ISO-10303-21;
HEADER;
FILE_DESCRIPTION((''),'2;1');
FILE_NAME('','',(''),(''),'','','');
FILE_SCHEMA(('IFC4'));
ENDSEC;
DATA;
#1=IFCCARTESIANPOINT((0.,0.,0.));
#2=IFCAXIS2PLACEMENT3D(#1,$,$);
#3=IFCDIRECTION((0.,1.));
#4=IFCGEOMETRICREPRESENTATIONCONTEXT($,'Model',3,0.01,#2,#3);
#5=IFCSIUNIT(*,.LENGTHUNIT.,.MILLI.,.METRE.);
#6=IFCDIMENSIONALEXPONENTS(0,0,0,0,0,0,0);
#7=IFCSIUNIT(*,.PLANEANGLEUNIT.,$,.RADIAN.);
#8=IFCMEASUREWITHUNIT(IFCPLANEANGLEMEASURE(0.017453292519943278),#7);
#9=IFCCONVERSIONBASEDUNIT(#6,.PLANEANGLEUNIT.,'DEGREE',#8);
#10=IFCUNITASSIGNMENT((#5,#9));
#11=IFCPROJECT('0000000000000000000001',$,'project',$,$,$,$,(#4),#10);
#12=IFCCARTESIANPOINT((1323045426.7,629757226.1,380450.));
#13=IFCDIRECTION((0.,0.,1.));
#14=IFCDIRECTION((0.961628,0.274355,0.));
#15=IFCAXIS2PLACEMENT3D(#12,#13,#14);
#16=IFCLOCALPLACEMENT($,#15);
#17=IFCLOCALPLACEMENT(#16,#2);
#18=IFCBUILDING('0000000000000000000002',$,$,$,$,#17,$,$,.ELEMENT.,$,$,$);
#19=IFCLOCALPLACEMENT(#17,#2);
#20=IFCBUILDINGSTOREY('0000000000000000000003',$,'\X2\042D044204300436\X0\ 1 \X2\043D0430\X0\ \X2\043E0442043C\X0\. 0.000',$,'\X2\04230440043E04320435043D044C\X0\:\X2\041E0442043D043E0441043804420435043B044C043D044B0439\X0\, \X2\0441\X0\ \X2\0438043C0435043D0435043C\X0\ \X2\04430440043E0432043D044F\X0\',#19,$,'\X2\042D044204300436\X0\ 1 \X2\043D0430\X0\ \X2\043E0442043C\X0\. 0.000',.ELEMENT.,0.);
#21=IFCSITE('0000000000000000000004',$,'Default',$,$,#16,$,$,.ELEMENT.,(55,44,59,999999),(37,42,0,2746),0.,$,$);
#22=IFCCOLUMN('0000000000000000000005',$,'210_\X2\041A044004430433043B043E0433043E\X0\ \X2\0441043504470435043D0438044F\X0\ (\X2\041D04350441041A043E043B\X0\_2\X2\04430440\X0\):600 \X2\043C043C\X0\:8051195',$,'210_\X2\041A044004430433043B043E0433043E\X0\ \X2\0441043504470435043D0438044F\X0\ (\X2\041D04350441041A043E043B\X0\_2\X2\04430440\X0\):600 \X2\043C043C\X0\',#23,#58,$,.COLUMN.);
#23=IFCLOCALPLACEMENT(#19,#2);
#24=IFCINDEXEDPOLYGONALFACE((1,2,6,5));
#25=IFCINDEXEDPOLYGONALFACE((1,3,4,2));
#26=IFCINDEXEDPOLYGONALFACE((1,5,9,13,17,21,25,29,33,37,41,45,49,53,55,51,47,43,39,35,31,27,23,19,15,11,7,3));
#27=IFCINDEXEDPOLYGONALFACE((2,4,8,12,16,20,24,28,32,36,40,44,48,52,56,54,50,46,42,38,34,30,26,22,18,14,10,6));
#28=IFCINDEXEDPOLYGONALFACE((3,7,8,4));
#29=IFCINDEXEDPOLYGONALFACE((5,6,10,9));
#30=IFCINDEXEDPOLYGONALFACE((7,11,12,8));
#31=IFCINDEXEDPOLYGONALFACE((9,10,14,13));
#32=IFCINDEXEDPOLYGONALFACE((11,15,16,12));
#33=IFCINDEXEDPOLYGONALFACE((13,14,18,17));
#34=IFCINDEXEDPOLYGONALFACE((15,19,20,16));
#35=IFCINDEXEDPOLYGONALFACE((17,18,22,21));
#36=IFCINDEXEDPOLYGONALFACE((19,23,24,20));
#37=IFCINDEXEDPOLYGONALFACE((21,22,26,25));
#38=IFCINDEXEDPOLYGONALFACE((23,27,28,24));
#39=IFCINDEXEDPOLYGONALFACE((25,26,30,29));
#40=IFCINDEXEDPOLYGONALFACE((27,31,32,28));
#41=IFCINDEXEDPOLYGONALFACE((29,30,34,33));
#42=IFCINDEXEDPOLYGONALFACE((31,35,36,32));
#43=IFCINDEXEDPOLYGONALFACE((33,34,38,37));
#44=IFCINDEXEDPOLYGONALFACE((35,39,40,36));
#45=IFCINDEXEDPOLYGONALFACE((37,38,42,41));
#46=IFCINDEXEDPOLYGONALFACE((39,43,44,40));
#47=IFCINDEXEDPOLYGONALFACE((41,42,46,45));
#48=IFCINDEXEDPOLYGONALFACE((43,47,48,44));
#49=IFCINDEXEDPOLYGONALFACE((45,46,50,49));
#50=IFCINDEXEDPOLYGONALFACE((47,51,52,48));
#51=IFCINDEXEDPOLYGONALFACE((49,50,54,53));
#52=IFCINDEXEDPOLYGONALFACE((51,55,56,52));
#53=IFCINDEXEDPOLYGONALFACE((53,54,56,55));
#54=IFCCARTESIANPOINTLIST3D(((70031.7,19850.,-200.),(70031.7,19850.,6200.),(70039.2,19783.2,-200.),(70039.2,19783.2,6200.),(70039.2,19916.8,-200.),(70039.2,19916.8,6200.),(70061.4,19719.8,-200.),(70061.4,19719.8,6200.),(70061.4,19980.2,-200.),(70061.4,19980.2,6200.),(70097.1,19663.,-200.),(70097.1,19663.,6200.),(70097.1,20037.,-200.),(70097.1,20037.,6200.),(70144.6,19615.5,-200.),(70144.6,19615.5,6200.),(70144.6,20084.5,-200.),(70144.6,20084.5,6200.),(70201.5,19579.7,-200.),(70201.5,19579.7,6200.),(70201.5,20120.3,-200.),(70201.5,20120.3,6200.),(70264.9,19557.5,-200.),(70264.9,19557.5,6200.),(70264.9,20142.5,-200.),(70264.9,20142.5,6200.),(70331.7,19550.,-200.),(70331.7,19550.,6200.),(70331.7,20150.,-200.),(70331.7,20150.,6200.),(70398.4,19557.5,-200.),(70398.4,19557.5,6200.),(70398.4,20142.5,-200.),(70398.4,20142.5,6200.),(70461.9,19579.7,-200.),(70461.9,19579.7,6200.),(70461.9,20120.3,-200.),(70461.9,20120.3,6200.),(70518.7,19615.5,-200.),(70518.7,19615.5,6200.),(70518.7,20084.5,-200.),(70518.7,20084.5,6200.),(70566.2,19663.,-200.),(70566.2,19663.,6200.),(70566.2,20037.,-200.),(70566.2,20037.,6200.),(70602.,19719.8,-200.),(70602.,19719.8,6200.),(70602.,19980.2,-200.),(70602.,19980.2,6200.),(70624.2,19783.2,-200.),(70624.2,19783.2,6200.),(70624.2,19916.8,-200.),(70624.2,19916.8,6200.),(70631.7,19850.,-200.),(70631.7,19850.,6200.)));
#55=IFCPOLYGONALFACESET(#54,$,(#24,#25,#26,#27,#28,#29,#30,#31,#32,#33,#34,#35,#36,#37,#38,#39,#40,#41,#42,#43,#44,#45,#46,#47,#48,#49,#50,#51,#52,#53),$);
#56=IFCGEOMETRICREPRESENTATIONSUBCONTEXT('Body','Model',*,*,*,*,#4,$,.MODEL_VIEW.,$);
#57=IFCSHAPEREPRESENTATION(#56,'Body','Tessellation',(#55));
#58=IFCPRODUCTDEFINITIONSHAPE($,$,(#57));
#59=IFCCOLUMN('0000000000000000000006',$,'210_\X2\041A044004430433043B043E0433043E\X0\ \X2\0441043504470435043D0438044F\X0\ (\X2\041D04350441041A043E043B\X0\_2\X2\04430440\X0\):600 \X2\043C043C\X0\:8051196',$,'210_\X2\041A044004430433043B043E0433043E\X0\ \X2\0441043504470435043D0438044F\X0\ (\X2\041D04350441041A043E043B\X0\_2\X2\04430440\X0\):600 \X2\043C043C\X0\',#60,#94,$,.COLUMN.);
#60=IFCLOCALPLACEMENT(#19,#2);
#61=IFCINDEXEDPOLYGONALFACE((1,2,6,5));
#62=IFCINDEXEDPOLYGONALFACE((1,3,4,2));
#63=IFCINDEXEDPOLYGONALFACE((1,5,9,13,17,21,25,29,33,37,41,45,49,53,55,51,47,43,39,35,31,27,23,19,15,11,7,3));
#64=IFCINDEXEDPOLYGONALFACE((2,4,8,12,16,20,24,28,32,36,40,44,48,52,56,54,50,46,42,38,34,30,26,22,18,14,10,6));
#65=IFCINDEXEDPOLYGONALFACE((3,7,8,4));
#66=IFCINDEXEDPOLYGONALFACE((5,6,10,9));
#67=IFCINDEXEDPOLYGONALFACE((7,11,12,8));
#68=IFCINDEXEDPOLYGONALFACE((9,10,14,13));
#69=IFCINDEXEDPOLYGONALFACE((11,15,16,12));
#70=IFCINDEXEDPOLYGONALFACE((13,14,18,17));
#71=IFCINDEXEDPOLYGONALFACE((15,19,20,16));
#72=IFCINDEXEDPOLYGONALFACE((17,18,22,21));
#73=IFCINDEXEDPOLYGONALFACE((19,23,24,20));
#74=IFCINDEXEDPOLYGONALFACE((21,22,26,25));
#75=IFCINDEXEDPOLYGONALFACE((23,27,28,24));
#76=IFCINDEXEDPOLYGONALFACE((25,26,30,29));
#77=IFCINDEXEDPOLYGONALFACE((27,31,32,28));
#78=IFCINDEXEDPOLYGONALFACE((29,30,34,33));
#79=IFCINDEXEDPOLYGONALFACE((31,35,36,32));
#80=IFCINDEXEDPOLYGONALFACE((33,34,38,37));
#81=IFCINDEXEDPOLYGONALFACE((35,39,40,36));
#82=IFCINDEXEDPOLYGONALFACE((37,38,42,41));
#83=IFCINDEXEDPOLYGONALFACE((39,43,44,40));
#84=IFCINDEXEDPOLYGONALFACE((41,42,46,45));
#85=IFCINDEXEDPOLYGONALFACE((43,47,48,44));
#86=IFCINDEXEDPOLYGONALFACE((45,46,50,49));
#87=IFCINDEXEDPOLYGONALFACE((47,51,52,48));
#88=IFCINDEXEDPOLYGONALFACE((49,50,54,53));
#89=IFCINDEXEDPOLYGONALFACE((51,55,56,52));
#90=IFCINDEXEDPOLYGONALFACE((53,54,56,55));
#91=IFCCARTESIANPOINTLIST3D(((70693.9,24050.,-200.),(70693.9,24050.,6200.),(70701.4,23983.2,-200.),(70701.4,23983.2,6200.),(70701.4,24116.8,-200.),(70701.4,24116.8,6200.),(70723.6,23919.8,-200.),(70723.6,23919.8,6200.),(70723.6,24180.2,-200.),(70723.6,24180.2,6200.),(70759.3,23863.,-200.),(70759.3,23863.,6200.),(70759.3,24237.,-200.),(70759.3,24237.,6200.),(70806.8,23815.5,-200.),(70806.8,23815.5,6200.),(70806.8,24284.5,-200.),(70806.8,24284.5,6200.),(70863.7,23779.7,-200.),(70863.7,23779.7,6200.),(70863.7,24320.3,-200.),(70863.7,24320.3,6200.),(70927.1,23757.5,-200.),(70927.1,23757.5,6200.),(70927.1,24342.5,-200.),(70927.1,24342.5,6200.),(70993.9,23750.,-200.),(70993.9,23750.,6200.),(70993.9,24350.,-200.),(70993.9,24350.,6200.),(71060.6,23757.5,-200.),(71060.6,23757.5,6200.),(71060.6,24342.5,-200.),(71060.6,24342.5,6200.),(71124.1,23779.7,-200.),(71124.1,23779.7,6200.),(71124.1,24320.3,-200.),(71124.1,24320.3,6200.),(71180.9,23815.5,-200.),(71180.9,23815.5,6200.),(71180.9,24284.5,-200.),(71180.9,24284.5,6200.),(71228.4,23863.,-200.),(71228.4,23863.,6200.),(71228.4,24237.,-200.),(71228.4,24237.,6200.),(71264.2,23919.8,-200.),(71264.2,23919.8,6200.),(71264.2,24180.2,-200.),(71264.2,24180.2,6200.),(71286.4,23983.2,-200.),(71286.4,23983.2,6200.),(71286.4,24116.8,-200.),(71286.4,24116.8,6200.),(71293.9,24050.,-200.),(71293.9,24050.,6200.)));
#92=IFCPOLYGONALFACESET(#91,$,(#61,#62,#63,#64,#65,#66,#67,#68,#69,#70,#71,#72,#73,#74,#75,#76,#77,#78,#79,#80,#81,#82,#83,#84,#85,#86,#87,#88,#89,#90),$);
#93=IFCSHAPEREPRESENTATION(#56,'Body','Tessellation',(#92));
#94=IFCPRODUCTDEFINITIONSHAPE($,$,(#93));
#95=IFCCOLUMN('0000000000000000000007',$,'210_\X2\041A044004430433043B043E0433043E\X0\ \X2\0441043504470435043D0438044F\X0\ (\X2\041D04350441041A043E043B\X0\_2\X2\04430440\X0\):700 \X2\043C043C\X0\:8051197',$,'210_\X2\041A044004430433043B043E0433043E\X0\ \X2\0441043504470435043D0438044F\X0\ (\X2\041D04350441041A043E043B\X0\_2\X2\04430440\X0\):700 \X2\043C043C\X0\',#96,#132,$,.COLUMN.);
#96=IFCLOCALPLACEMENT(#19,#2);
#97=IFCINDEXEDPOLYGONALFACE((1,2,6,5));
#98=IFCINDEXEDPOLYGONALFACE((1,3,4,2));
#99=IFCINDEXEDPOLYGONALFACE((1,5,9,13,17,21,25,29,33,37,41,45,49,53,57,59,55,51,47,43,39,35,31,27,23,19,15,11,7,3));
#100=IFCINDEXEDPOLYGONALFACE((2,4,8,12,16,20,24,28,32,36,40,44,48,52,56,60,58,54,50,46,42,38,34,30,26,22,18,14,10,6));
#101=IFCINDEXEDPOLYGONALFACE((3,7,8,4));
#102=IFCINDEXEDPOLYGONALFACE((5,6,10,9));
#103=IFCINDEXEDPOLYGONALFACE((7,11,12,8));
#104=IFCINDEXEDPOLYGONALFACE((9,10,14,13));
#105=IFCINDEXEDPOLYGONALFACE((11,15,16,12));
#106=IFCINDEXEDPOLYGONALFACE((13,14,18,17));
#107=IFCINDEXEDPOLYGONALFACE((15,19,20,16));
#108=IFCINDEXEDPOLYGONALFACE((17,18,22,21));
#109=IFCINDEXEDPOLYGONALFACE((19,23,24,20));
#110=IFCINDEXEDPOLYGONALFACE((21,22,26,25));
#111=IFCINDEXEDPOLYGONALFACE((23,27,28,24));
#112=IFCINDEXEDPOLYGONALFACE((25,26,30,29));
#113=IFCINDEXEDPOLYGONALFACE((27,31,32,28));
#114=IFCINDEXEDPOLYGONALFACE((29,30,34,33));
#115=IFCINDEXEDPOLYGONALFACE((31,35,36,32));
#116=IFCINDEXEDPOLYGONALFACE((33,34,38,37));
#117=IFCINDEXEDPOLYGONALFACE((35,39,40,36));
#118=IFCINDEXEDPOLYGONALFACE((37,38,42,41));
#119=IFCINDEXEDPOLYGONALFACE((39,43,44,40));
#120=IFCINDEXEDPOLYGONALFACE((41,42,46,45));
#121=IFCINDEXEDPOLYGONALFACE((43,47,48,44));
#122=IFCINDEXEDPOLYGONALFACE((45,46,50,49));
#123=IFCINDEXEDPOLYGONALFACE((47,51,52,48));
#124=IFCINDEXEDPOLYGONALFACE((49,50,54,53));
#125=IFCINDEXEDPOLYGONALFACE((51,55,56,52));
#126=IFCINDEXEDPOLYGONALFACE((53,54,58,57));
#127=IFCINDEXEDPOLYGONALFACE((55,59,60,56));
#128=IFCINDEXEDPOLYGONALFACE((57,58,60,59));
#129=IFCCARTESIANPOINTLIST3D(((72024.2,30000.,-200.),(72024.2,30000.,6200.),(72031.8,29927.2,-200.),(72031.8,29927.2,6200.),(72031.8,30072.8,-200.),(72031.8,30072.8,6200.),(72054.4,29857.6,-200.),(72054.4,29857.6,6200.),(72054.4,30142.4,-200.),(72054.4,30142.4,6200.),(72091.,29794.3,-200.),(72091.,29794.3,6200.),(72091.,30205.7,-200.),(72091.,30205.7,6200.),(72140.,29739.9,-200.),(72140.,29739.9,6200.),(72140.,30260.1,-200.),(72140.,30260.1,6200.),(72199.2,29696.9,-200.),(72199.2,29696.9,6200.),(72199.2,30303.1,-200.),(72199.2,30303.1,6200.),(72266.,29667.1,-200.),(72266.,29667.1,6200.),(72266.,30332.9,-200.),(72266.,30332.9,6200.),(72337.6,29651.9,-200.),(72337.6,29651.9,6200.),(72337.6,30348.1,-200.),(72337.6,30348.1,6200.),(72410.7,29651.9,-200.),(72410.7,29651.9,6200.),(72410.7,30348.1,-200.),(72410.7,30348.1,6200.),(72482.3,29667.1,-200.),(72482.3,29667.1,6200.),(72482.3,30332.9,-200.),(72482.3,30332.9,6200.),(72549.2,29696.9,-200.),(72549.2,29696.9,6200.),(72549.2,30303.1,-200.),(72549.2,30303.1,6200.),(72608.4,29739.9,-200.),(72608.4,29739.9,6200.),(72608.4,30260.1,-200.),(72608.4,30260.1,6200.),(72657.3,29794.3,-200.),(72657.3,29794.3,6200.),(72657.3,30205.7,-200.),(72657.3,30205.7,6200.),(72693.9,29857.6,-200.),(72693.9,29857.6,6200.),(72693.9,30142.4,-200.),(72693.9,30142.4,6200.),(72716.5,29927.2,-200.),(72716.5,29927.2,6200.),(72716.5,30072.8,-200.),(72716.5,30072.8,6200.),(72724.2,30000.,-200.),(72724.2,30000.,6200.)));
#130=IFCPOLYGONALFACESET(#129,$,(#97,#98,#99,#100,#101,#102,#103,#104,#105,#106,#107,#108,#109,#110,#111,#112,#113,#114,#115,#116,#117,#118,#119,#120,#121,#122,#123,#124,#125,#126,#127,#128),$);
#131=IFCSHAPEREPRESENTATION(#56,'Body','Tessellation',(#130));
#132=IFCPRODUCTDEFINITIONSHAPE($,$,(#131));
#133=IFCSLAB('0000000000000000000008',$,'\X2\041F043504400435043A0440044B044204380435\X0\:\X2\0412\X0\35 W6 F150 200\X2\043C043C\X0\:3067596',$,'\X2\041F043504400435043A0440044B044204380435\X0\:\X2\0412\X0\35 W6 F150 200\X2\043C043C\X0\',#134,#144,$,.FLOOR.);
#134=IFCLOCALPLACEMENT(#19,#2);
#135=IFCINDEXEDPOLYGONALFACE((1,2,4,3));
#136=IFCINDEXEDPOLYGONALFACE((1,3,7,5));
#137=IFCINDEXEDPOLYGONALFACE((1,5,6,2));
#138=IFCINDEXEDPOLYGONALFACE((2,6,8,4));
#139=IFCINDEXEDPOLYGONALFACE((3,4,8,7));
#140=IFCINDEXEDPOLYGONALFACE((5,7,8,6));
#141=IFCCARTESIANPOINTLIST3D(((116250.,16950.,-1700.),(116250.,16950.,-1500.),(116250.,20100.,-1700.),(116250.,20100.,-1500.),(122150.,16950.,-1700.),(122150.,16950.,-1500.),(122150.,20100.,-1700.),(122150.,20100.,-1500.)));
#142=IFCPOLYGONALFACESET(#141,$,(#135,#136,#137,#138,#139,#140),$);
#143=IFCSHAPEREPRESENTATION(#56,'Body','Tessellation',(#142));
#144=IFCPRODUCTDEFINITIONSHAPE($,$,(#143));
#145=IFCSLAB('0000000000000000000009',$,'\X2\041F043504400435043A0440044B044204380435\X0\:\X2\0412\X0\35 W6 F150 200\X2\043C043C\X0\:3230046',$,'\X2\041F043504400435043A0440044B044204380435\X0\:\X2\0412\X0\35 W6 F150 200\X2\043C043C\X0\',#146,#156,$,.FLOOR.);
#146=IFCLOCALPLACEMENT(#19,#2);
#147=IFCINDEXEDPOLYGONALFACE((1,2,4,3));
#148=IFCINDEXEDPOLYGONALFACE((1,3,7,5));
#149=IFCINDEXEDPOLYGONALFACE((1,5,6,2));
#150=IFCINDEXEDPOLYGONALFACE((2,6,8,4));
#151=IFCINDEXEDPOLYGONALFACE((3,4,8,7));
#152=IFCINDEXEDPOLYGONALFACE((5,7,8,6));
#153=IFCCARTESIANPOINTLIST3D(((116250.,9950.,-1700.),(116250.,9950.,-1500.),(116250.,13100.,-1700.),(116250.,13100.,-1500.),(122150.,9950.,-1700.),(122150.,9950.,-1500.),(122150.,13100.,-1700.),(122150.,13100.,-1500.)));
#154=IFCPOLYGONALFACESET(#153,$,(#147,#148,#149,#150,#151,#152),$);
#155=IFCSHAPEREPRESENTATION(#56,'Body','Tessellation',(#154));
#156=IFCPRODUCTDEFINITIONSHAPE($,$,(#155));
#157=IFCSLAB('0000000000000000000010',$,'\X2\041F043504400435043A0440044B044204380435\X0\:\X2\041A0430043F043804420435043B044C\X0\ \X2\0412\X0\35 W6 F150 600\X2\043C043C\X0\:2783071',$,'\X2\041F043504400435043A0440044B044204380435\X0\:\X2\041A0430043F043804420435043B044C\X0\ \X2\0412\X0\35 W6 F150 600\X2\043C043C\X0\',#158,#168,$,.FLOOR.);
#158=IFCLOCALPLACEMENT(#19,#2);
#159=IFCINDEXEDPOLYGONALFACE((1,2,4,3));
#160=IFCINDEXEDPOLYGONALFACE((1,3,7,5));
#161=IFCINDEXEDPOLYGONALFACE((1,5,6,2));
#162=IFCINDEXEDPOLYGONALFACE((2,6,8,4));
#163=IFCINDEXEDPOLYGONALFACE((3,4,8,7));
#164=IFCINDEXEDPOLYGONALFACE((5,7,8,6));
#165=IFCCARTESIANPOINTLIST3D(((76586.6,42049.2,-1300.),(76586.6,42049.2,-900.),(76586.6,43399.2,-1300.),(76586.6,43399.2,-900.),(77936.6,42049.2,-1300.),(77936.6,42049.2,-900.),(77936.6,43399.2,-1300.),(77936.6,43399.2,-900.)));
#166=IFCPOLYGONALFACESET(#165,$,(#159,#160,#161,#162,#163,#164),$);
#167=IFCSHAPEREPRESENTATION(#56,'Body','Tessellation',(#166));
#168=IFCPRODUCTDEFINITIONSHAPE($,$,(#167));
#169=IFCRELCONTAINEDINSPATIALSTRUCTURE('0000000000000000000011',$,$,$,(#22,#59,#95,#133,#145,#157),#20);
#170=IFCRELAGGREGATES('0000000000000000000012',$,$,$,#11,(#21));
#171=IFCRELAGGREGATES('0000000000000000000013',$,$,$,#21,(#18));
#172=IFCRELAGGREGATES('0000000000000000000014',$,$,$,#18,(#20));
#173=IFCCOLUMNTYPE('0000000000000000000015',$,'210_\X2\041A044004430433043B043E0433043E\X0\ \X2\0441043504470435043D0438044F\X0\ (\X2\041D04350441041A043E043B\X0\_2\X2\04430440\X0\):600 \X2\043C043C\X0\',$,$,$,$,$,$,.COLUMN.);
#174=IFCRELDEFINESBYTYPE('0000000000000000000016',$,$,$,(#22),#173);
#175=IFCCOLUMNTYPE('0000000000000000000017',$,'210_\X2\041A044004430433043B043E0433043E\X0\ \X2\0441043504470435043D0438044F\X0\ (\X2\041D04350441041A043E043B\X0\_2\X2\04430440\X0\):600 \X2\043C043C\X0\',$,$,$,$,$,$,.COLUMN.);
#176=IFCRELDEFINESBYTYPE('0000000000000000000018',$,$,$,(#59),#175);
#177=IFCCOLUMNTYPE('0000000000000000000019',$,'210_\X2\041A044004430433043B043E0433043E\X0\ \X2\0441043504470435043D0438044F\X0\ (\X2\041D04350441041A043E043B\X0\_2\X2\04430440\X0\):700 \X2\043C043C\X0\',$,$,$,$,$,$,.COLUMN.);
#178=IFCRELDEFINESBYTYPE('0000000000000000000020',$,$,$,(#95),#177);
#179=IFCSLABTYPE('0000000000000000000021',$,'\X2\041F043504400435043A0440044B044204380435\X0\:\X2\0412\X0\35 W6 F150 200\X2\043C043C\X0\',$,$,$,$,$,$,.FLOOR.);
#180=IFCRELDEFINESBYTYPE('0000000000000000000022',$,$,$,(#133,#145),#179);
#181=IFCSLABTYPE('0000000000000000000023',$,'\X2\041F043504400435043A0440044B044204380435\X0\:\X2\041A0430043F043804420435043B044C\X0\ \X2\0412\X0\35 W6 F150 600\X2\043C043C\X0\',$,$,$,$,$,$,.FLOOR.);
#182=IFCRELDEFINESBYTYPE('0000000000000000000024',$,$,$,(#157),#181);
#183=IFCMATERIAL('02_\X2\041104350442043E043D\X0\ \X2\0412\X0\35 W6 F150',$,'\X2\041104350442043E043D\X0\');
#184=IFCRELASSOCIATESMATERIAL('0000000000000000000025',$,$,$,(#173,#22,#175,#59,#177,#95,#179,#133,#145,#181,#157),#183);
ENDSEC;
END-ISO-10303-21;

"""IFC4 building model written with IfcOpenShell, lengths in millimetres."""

from ifc_helpers import new_model, entity, si_unit, converted_unit, direction, frame, origin, place, context, subcontext, project, spatial, arc, indexed_curve, outline, extrude, source, transform, mapped, material, type_object, type_shapes, element, save


model = new_model("IFC4")

# Units and contexts
model_context = context("Model", 3, precision=0.01, world=origin(), true_north=direction((0.0, 1.0)))
body_context = subcontext(model_context, "Body", "Model", "MODEL_VIEW")
ifc_project = project(units=[si_unit("LENGTHUNIT", "METRE", prefix="MILLI"), converted_unit("PLANEANGLEUNIT", "DEGREE", entity("IfcPlaneAngleMeasure", 0.017453292519943278), si_unit("PLANEANGLEUNIT", "RADIAN"), dimensions=[0, 0, 0, 0, 0, 0, 0])], contexts=[model_context])

# Site, building, storey
site_placement = place(None, frame((1323045426.7, 629757226.1, 380450.0), z_axis=(0.0, 0.0, 1.0), x_axis=(0.961628, 0.274355, 0.0)))
site = spatial("IfcSite", under=ifc_project, at=site_placement, Name="Default", CompositionType="ELEMENT", RefLatitude=(55, 44, 59, 999999), RefLongitude=(37, 42, 0, 2746), RefElevation=0.0)
building_placement = place(site_placement, origin())
building = spatial("IfcBuilding", under=site, at=building_placement, CompositionType="ELEMENT")
storey_placement = place(building_placement, origin())
storey = spatial("IfcBuildingStorey", under=building, at=storey_placement, Name="Этаж 1 на отм. 0.000", ObjectType="Уровень:Относительный, с именем уровня", LongName="Этаж 1 на отм. 0.000", CompositionType="ELEMENT", Elevation=0.0)

# Columns
ifc_material = material(Name="02_Бетон В35 W6 F150", Category="Бетон")
column_type_1 = type_object("IfcColumnType", Name="210_Круглого сечения (НесКол_2ур):600 мм", PredefinedType="COLUMN", material=ifc_material)
shared_shape_1 = source(origin(), body_context, "Body", "SweptSolid", [
    extrude(outline(indexed_curve([(-300.0, 0.0), (0.0, -300.0), (300.0, 0.0), (0.0, 300.0)], segments=[arc(1, 2, 3), arc(3, 4, 1)], self_intersect=False)), frame((70331.7, 19850.0, -200.0)), (0.0, 0.0, 1.0), 6400.0),
])
type_shapes(column_type_1, [shared_shape_1])
column_1_placement = place(storey_placement, origin())
element("IfcColumn", 1, at=column_1_placement, inside=storey, type_object=column_type_1, material=ifc_material, Name="210_Круглого сечения (НесКол_2ур):600 мм:8051195", ObjectType="210_Круглого сечения (НесКол_2ур):600 мм", PredefinedType="COLUMN", context=body_context, shape_type="MappedRepresentation", body=[
    mapped(shared_shape_1, transform((0.0, 0.0, 0.0), scale=1.0)),
])
column_type_2 = type_object("IfcColumnType", Name="210_Круглого сечения (НесКол_2ур):600 мм", PredefinedType="COLUMN", material=ifc_material)
shared_shape_2 = source(origin(), body_context, "Body", "SweptSolid", [
    extrude(outline(indexed_curve([(-300.0, 0.0), (0.0, -300.0), (300.0, 0.0), (0.0, 300.0)], segments=[arc(1, 2, 3), arc(3, 4, 1)], self_intersect=False)), frame((70993.9, 24050.0, -200.0)), (0.0, 0.0, 1.0), 6400.0),
])
type_shapes(column_type_2, [shared_shape_2])
column_2_placement = place(storey_placement, origin())
element("IfcColumn", 2, at=column_2_placement, inside=storey, type_object=column_type_2, material=ifc_material, Name="210_Круглого сечения (НесКол_2ур):600 мм:8051196", ObjectType="210_Круглого сечения (НесКол_2ур):600 мм", PredefinedType="COLUMN", context=body_context, shape_type="MappedRepresentation", body=[
    mapped(shared_shape_2, transform((0.0, 0.0, 0.0), scale=1.0)),
])
column_type_3 = type_object("IfcColumnType", Name="210_Круглого сечения (НесКол_2ур):700 мм", PredefinedType="COLUMN", material=ifc_material)
shared_shape_3 = source(origin(), body_context, "Body", "SweptSolid", [
    extrude(outline(indexed_curve([(-350.0, 0.0), (0.0, -350.0), (350.0, 0.0), (0.0, 350.0)], segments=[arc(1, 2, 3), arc(3, 4, 1)], self_intersect=False)), frame((72374.2, 30000.0, -200.0)), (0.0, 0.0, 1.0), 6400.0),
])
type_shapes(column_type_3, [shared_shape_3])
column_3_placement = place(storey_placement, origin())
element("IfcColumn", 3, at=column_3_placement, inside=storey, type_object=column_type_3, material=ifc_material, Name="210_Круглого сечения (НесКол_2ур):700 мм:8051197", ObjectType="210_Круглого сечения (НесКол_2ур):700 мм", PredefinedType="COLUMN", context=body_context, shape_type="MappedRepresentation", body=[
    mapped(shared_shape_3, transform((0.0, 0.0, 0.0), scale=1.0)),
])

# Slabs
slab_type_1 = type_object("IfcSlabType", Name="Перекрытие:В35 W6 F150 200мм", PredefinedType="FLOOR", material=ifc_material)
slab_1_placement = place(storey_placement, origin())
element("IfcSlab", 4, at=slab_1_placement, inside=storey, type_object=slab_type_1, material=ifc_material, Name="Перекрытие:В35 W6 F150 200мм:3067596", ObjectType="Перекрытие:В35 W6 F150 200мм", PredefinedType="FLOOR", context=body_context, shape_type="SweptSolid", body=[
    extrude(outline(indexed_curve([(-1575.0, -2950.0), (1575.0, -2950.0), (1575.0, 2950.0), (-1575.0, 2950.0), (-1575.0, -2950.0)], self_intersect=False)), frame((119200.0, 18525.0, -1500.0), z_axis=(0.0, 0.0, -1.0), x_axis=(0.0, 1.0, 0.0)), (0.0, 0.0, 1.0), 200.0),
])
slab_2_placement = place(storey_placement, origin())
element("IfcSlab", 5, at=slab_2_placement, inside=storey, type_object=slab_type_1, material=ifc_material, Name="Перекрытие:В35 W6 F150 200мм:3230046", ObjectType="Перекрытие:В35 W6 F150 200мм", PredefinedType="FLOOR", context=body_context, shape_type="SweptSolid", body=[
    extrude(outline(indexed_curve([(-1575.0, -2950.0), (1575.0, -2950.0), (1575.0, 2950.0), (-1575.0, 2950.0), (-1575.0, -2950.0)], self_intersect=False)), frame((119200.0, 11525.0, -1500.0), z_axis=(0.0, 0.0, -1.0), x_axis=(0.0, 1.0, 0.0)), (0.0, 0.0, 1.0), 200.0),
])
slab_type_2 = type_object("IfcSlabType", Name="Перекрытие:Капитель В35 W6 F150 600мм", PredefinedType="FLOOR", material=ifc_material)
slab_3_placement = place(storey_placement, origin())
element("IfcSlab", 6, at=slab_3_placement, inside=storey, type_object=slab_type_2, material=ifc_material, Name="Перекрытие:Капитель В35 W6 F150 600мм:2783071", ObjectType="Перекрытие:Капитель В35 W6 F150 600мм", PredefinedType="FLOOR", context=body_context, shape_type="SweptSolid", body=[
    extrude(outline(indexed_curve([(-675.0, -675.0), (675.0, -675.0), (675.0, 675.0), (-675.0, 675.0), (-675.0, -675.0)], self_intersect=False)), frame((77261.6, 42724.2, -1300.0)), (0.0, 0.0, 1.0), 400.0),
])

save(model, "model.ifc")
